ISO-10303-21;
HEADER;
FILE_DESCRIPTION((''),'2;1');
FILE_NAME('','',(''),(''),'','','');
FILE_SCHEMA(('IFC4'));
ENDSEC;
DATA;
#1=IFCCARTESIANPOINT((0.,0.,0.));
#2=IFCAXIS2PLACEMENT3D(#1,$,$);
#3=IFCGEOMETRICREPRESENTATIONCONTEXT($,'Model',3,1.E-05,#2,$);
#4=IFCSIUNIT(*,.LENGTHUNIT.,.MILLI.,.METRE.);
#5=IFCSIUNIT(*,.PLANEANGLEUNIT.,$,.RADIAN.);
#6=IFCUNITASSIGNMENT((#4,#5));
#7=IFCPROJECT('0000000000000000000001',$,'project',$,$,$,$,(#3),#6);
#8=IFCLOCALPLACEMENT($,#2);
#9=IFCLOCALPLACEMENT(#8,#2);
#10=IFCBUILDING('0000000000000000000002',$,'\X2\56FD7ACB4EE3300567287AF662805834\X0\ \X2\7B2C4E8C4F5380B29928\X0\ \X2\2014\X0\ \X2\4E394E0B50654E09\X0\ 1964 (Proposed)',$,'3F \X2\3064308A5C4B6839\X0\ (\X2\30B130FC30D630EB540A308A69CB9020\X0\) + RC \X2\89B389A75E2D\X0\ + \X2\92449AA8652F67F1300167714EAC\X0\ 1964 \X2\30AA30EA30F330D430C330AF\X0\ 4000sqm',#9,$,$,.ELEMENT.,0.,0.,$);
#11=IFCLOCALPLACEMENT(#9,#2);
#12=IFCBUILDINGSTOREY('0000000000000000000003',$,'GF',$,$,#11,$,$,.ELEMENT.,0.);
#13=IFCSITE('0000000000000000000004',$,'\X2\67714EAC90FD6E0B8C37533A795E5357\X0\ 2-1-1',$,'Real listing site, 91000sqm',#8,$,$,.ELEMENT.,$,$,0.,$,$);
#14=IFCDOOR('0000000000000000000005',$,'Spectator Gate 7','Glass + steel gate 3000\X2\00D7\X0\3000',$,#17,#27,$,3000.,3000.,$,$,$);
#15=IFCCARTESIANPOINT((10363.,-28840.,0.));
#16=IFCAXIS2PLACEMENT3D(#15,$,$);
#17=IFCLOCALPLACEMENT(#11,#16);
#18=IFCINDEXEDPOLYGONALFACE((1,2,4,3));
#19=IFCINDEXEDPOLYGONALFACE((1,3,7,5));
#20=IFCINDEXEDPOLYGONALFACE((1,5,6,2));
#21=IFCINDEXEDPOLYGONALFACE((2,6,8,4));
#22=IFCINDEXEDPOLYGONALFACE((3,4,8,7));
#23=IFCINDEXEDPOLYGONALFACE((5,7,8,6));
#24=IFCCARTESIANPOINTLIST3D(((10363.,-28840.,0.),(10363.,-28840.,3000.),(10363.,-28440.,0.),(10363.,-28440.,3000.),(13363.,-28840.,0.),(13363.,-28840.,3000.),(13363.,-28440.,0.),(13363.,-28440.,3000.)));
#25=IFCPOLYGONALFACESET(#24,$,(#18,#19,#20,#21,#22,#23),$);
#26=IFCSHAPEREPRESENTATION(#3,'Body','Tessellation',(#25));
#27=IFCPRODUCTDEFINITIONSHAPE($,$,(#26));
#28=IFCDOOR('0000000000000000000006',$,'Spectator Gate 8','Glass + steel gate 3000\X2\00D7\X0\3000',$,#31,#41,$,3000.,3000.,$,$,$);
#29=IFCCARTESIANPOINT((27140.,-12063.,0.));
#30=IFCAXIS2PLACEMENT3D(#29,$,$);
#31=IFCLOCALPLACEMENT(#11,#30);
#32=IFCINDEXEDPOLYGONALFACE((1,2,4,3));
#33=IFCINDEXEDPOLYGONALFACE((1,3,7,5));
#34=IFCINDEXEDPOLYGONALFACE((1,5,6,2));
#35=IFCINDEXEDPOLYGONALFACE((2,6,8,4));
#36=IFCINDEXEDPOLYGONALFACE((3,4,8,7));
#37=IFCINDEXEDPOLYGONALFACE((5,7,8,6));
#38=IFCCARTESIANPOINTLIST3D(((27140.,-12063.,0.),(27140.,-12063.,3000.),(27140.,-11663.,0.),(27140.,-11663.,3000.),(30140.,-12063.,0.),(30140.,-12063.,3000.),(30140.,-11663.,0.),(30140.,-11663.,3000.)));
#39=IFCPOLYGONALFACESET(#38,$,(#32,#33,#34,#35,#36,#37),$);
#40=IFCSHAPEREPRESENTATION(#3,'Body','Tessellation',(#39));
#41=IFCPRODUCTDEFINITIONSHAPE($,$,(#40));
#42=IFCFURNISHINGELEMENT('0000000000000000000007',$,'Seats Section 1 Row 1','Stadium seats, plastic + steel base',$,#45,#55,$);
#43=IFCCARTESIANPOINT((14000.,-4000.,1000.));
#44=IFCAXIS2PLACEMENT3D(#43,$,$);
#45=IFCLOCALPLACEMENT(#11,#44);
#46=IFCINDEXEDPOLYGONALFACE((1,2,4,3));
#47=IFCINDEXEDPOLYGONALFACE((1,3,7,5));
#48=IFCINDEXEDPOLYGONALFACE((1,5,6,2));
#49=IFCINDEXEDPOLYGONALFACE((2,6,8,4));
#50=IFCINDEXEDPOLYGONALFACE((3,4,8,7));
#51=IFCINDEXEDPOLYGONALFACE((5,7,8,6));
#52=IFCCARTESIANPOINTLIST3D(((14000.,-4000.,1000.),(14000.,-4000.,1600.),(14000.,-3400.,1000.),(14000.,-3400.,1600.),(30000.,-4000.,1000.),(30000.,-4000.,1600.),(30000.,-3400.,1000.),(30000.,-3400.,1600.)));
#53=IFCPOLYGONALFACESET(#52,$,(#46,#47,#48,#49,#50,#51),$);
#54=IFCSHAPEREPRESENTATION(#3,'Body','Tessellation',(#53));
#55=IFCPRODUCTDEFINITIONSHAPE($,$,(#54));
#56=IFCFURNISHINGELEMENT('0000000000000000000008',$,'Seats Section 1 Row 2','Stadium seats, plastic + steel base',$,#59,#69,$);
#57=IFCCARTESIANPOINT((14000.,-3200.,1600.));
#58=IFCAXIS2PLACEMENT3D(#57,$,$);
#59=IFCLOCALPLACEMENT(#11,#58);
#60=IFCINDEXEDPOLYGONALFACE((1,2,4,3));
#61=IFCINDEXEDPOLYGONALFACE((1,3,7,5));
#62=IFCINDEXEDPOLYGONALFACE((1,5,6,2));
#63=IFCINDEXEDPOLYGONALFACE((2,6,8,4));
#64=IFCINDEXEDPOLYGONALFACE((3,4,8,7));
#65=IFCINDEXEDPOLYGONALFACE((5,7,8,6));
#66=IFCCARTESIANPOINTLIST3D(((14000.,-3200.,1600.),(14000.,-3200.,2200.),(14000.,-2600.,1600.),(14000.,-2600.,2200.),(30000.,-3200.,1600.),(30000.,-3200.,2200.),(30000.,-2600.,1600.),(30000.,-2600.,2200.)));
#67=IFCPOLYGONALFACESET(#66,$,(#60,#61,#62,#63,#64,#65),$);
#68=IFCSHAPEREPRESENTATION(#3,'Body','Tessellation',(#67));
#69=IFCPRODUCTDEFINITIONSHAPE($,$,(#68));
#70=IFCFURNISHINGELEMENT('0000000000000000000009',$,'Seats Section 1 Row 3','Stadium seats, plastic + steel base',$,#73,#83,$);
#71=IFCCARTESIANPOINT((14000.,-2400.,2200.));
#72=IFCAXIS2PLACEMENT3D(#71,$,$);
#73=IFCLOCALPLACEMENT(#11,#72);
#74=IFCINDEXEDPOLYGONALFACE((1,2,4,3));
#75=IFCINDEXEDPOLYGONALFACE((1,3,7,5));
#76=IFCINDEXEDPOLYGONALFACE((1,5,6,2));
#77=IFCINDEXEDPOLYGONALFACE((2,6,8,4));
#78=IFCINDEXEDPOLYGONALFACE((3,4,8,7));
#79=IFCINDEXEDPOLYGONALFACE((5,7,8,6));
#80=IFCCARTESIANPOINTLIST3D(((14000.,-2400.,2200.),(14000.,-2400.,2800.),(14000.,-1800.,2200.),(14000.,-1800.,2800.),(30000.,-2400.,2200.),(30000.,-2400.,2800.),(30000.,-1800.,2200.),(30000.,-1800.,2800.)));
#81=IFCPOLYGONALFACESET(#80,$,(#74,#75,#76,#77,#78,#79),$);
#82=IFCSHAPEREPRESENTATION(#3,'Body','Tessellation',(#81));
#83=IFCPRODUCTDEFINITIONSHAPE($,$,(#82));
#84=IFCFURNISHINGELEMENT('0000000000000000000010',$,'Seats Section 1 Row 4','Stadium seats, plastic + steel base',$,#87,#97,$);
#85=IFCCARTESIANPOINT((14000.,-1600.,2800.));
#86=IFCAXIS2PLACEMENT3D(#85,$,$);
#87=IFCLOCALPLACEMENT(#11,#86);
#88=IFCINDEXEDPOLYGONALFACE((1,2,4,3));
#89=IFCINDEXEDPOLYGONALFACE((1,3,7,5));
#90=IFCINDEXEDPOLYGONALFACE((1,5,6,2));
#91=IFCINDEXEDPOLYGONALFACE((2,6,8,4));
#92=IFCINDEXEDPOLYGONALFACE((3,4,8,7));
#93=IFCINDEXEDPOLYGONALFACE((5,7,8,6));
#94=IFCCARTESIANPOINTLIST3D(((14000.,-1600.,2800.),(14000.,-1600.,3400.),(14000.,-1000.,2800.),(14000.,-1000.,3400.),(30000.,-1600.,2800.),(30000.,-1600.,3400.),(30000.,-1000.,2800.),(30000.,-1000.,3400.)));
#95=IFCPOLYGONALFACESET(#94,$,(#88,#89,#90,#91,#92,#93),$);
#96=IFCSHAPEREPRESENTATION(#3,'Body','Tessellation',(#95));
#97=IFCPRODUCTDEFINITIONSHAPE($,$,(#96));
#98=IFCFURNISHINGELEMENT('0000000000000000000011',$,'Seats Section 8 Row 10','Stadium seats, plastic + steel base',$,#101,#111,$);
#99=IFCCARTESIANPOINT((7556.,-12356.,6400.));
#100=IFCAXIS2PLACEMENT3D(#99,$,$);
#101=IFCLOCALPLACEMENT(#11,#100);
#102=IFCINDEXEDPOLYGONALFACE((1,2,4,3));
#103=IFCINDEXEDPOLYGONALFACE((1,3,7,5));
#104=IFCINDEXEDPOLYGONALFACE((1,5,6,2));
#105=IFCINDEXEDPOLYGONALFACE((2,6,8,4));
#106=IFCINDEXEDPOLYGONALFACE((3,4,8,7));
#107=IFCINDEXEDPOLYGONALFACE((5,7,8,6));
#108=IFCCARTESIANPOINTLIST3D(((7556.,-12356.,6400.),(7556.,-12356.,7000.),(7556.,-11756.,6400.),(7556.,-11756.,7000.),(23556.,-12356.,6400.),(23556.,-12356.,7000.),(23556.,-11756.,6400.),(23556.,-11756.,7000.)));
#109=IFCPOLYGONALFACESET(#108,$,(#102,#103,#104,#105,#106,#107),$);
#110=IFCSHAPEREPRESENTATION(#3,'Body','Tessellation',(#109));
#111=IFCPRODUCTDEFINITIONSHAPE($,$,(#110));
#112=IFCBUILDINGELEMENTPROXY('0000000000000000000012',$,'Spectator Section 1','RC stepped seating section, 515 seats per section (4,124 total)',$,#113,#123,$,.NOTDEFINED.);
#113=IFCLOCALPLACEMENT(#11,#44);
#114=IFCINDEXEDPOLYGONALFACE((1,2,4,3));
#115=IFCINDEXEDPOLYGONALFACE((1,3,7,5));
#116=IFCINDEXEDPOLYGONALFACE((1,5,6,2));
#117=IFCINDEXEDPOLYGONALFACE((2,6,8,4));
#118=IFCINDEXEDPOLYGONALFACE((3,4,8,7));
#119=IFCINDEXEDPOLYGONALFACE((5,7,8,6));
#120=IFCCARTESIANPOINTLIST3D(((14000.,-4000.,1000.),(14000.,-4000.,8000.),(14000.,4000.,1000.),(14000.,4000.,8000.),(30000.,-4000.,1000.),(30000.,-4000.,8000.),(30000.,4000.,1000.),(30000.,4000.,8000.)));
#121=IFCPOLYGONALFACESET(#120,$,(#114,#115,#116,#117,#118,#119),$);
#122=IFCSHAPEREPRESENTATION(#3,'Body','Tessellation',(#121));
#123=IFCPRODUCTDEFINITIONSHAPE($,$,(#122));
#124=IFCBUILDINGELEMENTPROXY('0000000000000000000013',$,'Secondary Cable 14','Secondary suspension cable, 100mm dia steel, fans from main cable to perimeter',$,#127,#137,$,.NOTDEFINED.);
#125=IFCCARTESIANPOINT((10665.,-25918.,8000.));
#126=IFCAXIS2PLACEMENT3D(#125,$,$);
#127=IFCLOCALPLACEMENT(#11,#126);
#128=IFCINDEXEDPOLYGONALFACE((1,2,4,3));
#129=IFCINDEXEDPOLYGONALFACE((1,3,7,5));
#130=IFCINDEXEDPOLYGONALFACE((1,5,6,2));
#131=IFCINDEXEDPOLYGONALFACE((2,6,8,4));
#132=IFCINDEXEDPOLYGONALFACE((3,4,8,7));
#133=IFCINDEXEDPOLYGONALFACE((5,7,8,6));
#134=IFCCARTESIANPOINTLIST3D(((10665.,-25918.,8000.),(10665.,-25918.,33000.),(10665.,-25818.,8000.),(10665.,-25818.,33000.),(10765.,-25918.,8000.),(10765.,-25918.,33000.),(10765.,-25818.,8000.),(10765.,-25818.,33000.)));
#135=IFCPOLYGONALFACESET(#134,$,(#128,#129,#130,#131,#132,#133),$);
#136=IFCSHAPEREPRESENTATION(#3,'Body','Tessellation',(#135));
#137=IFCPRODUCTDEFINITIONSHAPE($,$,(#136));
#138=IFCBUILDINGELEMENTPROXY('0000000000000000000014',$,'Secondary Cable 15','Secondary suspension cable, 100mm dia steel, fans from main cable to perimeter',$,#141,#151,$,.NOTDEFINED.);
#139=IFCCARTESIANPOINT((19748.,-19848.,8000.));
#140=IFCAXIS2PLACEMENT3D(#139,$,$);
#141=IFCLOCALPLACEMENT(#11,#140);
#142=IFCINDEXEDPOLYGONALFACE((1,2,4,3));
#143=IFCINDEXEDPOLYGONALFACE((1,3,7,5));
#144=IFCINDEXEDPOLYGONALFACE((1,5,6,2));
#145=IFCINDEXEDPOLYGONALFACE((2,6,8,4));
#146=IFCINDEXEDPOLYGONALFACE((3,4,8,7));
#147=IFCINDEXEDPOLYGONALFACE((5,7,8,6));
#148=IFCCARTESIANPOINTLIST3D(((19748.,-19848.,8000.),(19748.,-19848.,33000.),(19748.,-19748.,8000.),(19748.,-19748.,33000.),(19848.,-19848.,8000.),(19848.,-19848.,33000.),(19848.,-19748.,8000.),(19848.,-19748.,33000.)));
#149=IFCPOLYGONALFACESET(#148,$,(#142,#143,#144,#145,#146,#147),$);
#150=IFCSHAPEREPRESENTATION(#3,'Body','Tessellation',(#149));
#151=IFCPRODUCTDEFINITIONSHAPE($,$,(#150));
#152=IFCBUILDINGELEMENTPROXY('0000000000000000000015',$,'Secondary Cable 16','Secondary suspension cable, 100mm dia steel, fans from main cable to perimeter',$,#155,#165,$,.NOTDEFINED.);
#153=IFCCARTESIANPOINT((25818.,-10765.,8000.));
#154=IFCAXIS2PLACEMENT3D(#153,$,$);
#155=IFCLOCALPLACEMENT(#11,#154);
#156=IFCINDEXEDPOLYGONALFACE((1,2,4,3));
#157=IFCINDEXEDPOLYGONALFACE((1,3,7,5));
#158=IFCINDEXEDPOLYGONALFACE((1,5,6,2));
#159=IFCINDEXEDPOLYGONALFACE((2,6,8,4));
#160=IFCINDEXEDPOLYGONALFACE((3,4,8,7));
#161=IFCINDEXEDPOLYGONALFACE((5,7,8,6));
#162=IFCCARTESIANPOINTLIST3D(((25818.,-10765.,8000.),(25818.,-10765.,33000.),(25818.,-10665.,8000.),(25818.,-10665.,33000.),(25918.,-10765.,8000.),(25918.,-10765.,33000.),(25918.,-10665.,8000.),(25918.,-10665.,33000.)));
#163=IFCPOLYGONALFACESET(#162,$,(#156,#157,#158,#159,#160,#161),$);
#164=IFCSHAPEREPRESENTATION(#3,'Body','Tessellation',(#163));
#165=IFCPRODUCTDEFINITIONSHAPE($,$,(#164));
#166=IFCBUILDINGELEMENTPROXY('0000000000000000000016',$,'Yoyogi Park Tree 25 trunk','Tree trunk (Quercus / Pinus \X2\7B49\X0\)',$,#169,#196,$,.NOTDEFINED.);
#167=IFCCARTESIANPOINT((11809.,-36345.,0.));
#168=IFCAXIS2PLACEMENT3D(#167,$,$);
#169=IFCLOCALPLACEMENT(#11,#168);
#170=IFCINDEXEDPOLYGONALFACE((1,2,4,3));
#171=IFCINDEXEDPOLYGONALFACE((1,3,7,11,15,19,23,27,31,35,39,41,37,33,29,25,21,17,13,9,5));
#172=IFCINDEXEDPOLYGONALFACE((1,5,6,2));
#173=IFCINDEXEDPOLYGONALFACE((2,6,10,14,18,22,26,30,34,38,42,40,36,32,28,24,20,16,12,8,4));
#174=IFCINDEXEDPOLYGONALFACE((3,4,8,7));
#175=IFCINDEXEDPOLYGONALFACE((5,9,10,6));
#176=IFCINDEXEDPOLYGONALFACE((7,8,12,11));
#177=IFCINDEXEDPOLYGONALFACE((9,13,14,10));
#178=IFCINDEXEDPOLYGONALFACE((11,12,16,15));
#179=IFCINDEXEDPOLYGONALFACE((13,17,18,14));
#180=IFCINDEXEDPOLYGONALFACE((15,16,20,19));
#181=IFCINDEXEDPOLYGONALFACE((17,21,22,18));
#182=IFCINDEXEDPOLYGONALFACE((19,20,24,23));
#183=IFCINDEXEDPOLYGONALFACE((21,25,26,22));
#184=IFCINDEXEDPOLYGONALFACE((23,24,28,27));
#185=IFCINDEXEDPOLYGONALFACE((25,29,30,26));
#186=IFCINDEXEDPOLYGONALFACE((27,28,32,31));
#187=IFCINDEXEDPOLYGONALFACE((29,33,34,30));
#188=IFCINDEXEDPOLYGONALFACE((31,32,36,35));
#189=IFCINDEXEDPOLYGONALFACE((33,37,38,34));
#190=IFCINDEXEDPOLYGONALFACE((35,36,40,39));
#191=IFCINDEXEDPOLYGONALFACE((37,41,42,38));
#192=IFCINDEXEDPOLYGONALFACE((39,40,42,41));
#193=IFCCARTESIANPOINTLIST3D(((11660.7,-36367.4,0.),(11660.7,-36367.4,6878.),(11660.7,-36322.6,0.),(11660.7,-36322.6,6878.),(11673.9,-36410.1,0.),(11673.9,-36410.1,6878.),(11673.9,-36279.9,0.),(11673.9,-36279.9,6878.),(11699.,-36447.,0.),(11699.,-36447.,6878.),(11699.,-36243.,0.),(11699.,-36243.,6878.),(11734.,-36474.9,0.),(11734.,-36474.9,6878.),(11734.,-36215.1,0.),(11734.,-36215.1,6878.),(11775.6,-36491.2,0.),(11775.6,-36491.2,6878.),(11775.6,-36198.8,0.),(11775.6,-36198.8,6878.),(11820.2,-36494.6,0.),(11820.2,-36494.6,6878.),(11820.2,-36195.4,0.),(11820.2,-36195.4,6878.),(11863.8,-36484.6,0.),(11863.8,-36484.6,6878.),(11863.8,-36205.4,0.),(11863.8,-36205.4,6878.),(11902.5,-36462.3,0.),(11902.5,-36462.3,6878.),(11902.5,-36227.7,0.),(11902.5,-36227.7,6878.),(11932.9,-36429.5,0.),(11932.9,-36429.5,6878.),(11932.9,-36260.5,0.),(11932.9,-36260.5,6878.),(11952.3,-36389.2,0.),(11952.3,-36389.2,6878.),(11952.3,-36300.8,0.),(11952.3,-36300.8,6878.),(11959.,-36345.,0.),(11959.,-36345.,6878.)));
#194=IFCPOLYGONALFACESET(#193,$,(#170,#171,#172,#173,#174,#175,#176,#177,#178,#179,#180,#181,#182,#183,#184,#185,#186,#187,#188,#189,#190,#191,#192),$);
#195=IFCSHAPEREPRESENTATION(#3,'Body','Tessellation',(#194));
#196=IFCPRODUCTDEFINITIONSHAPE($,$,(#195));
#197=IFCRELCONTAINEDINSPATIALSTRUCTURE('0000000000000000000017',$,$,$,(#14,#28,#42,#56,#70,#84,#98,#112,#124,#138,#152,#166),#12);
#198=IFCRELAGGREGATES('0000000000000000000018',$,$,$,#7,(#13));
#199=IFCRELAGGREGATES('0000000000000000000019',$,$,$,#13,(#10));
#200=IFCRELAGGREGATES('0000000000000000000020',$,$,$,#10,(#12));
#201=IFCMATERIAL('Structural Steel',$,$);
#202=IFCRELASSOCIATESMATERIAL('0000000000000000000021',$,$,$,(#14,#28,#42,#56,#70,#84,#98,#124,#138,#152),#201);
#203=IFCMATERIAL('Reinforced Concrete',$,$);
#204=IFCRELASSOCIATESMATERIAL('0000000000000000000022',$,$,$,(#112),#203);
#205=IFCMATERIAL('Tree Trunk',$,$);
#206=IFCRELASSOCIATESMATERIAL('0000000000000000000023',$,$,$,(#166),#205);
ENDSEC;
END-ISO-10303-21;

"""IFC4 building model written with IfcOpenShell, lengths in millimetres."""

from ifc_helpers import new_model, si_unit, frame, frame_2d, origin, origin_2d, place, context, project, spatial, rectangle, circle, extrude, material, element, save


model = new_model("IFC4")

# Units and contexts
model_context = context("Model", 3, precision=1e-05, world=origin())
ifc_project = project(units=[si_unit("LENGTHUNIT", "METRE", prefix="MILLI"), si_unit("PLANEANGLEUNIT", "RADIAN")], contexts=[model_context])

# Site, building, storey
site_placement = place(None, origin())
site = spatial("IfcSite", under=ifc_project, at=site_placement, Name="東京都渋谷区神南 2-1-1", ObjectType="Real listing site, 91000sqm", CompositionType="ELEMENT", RefElevation=0.0)
building_placement = place(site_placement, origin())
building = spatial("IfcBuilding", under=site, at=building_placement, Name="国立代々木競技場 第二体育館 — 丹下健三 1964 (Proposed)", ObjectType="3F つり屋根 (ケーブル吊り構造) + RC 観覧席 + 鉄骨支柱、東京 1964 オリンピック 4000sqm", CompositionType="ELEMENT", ElevationOfRefHeight=0.0, ElevationOfTerrain=0.0)
storey_placement = place(building_placement, origin())
storey = spatial("IfcBuildingStorey", under=building, at=storey_placement, Name="GF", CompositionType="ELEMENT", Elevation=0.0)

# Doors
ifc_material_1 = material(Name="Structural Steel")
door_1_placement = place(storey_placement, frame((10363.0, -28840.0, 0.0)))
element("IfcDoor", 1, at=door_1_placement, inside=storey, material=ifc_material_1, Name="Spectator Gate 7", Description="Glass + steel gate 3000×3000", OverallHeight=3000.0, OverallWidth=3000.0, context=model_context, shape_type="SweptSolid", body=[
    extrude(rectangle(XDim=3000.0, YDim=400.0, at=frame_2d((1500.0, 200.0))), frame((10363.0, -28840.0, 0.0)), (0.0, 0.0, 1.0), 3000.0),
])
door_2_placement = place(storey_placement, frame((27140.0, -12063.0, 0.0)))
element("IfcDoor", 2, at=door_2_placement, inside=storey, material=ifc_material_1, Name="Spectator Gate 8", Description="Glass + steel gate 3000×3000", OverallHeight=3000.0, OverallWidth=3000.0, context=model_context, shape_type="SweptSolid", body=[
    extrude(rectangle(XDim=3000.0, YDim=400.0, at=frame_2d((1500.0, 200.0))), frame((27140.0, -12063.0, 0.0)), (0.0, 0.0, 1.0), 3000.0),
])

# Furnishing elements
furnishing_1_placement = place(storey_placement, frame((14000.0, -4000.0, 1000.0)))
element("IfcFurnishingElement", 3, at=furnishing_1_placement, inside=storey, material=ifc_material_1, Name="Seats Section 1 Row 1", Description="Stadium seats, plastic + steel base", context=model_context, shape_type="SweptSolid", body=[
    extrude(rectangle(XDim=16000.0, YDim=600.0, at=frame_2d((8000.0, 300.0))), frame((14000.0, -4000.0, 1000.0)), (0.0, 0.0, 1.0), 600.0),
])
furnishing_2_placement = place(storey_placement, frame((14000.0, -3200.0, 1600.0)))
element("IfcFurnishingElement", 4, at=furnishing_2_placement, inside=storey, material=ifc_material_1, Name="Seats Section 1 Row 2", Description="Stadium seats, plastic + steel base", context=model_context, shape_type="SweptSolid", body=[
    extrude(rectangle(XDim=16000.0, YDim=600.0, at=frame_2d((8000.0, 300.0))), frame((14000.0, -3200.0, 1600.0)), (0.0, 0.0, 1.0), 600.0),
])
furnishing_3_placement = place(storey_placement, frame((14000.0, -2400.0, 2200.0)))
element("IfcFurnishingElement", 5, at=furnishing_3_placement, inside=storey, material=ifc_material_1, Name="Seats Section 1 Row 3", Description="Stadium seats, plastic + steel base", context=model_context, shape_type="SweptSolid", body=[
    extrude(rectangle(XDim=16000.0, YDim=600.0, at=frame_2d((8000.0, 300.0))), frame((14000.0, -2400.0, 2200.0)), (0.0, 0.0, 1.0), 600.0),
])
furnishing_4_placement = place(storey_placement, frame((14000.0, -1600.0, 2800.0)))
element("IfcFurnishingElement", 6, at=furnishing_4_placement, inside=storey, material=ifc_material_1, Name="Seats Section 1 Row 4", Description="Stadium seats, plastic + steel base", context=model_context, shape_type="SweptSolid", body=[
    extrude(rectangle(XDim=16000.0, YDim=600.0, at=frame_2d((8000.0, 300.0))), frame((14000.0, -1600.0, 2800.0)), (0.0, 0.0, 1.0), 600.0),
])
furnishing_5_placement = place(storey_placement, frame((7556.0, -12356.0, 6400.0)))
element("IfcFurnishingElement", 7, at=furnishing_5_placement, inside=storey, material=ifc_material_1, Name="Seats Section 8 Row 10", Description="Stadium seats, plastic + steel base", context=model_context, shape_type="SweptSolid", body=[
    extrude(rectangle(XDim=16000.0, YDim=600.0, at=frame_2d((8000.0, 300.0))), frame((7556.0, -12356.0, 6400.0)), (0.0, 0.0, 1.0), 600.0),
])

# Building element proxies
ifc_material_2 = material(Name="Reinforced Concrete")
proxy_1_placement = place(storey_placement, frame((14000.0, -4000.0, 1000.0)))
element("IfcBuildingElementProxy", 8, at=proxy_1_placement, inside=storey, material=ifc_material_2, Name="Spectator Section 1", Description="RC stepped seating section, 515 seats per section (4,124 total)", PredefinedType="NOTDEFINED", context=model_context, shape_type="SweptSolid", body=[
    extrude(rectangle(XDim=16000.0, YDim=8000.0, at=frame_2d((8000.0, 4000.0))), frame((14000.0, -4000.0, 1000.0)), (0.0, 0.0, 1.0), 7000.0),
])
proxy_2_placement = place(storey_placement, frame((10665.0, -25918.0, 8000.0)))
element("IfcBuildingElementProxy", 9, at=proxy_2_placement, inside=storey, material=ifc_material_1, Name="Secondary Cable 14", Description="Secondary suspension cable, 100mm dia steel, fans from main cable to perimeter", PredefinedType="NOTDEFINED", context=model_context, shape_type="SweptSolid", body=[
    extrude(rectangle(XDim=100.0, YDim=100.0, at=frame_2d((50.0, 50.0))), frame((10665.0, -25918.0, 8000.0)), (0.0, 0.0, 1.0), 25000.0),
])
proxy_3_placement = place(storey_placement, frame((19748.0, -19848.0, 8000.0)))
element("IfcBuildingElementProxy", 10, at=proxy_3_placement, inside=storey, material=ifc_material_1, Name="Secondary Cable 15", Description="Secondary suspension cable, 100mm dia steel, fans from main cable to perimeter", PredefinedType="NOTDEFINED", context=model_context, shape_type="SweptSolid", body=[
    extrude(rectangle(XDim=100.0, YDim=100.0, at=frame_2d((50.0, 50.0))), frame((19748.0, -19848.0, 8000.0)), (0.0, 0.0, 1.0), 25000.0),
])
proxy_4_placement = place(storey_placement, frame((25818.0, -10765.0, 8000.0)))
element("IfcBuildingElementProxy", 11, at=proxy_4_placement, inside=storey, material=ifc_material_1, Name="Secondary Cable 16", Description="Secondary suspension cable, 100mm dia steel, fans from main cable to perimeter", PredefinedType="NOTDEFINED", context=model_context, shape_type="SweptSolid", body=[
    extrude(rectangle(XDim=100.0, YDim=100.0, at=frame_2d((50.0, 50.0))), frame((25818.0, -10765.0, 8000.0)), (0.0, 0.0, 1.0), 25000.0),
])
ifc_material_3 = material(Name="Tree Trunk")
proxy_5_placement = place(storey_placement, frame((11809.0, -36345.0, 0.0)))
element("IfcBuildingElementProxy", 12, at=proxy_5_placement, inside=storey, material=ifc_material_3, Name="Yoyogi Park Tree 25 trunk", Description="Tree trunk (Quercus / Pinus 等)", PredefinedType="NOTDEFINED", context=model_context, shape_type="SweptSolid", body=[
    extrude(circle(Radius=150.0, at=origin_2d()), frame((11809.0, -36345.0, 0.0)), (0.0, 0.0, 1.0), 6878.0),
])

save(model, "model.ifc")
